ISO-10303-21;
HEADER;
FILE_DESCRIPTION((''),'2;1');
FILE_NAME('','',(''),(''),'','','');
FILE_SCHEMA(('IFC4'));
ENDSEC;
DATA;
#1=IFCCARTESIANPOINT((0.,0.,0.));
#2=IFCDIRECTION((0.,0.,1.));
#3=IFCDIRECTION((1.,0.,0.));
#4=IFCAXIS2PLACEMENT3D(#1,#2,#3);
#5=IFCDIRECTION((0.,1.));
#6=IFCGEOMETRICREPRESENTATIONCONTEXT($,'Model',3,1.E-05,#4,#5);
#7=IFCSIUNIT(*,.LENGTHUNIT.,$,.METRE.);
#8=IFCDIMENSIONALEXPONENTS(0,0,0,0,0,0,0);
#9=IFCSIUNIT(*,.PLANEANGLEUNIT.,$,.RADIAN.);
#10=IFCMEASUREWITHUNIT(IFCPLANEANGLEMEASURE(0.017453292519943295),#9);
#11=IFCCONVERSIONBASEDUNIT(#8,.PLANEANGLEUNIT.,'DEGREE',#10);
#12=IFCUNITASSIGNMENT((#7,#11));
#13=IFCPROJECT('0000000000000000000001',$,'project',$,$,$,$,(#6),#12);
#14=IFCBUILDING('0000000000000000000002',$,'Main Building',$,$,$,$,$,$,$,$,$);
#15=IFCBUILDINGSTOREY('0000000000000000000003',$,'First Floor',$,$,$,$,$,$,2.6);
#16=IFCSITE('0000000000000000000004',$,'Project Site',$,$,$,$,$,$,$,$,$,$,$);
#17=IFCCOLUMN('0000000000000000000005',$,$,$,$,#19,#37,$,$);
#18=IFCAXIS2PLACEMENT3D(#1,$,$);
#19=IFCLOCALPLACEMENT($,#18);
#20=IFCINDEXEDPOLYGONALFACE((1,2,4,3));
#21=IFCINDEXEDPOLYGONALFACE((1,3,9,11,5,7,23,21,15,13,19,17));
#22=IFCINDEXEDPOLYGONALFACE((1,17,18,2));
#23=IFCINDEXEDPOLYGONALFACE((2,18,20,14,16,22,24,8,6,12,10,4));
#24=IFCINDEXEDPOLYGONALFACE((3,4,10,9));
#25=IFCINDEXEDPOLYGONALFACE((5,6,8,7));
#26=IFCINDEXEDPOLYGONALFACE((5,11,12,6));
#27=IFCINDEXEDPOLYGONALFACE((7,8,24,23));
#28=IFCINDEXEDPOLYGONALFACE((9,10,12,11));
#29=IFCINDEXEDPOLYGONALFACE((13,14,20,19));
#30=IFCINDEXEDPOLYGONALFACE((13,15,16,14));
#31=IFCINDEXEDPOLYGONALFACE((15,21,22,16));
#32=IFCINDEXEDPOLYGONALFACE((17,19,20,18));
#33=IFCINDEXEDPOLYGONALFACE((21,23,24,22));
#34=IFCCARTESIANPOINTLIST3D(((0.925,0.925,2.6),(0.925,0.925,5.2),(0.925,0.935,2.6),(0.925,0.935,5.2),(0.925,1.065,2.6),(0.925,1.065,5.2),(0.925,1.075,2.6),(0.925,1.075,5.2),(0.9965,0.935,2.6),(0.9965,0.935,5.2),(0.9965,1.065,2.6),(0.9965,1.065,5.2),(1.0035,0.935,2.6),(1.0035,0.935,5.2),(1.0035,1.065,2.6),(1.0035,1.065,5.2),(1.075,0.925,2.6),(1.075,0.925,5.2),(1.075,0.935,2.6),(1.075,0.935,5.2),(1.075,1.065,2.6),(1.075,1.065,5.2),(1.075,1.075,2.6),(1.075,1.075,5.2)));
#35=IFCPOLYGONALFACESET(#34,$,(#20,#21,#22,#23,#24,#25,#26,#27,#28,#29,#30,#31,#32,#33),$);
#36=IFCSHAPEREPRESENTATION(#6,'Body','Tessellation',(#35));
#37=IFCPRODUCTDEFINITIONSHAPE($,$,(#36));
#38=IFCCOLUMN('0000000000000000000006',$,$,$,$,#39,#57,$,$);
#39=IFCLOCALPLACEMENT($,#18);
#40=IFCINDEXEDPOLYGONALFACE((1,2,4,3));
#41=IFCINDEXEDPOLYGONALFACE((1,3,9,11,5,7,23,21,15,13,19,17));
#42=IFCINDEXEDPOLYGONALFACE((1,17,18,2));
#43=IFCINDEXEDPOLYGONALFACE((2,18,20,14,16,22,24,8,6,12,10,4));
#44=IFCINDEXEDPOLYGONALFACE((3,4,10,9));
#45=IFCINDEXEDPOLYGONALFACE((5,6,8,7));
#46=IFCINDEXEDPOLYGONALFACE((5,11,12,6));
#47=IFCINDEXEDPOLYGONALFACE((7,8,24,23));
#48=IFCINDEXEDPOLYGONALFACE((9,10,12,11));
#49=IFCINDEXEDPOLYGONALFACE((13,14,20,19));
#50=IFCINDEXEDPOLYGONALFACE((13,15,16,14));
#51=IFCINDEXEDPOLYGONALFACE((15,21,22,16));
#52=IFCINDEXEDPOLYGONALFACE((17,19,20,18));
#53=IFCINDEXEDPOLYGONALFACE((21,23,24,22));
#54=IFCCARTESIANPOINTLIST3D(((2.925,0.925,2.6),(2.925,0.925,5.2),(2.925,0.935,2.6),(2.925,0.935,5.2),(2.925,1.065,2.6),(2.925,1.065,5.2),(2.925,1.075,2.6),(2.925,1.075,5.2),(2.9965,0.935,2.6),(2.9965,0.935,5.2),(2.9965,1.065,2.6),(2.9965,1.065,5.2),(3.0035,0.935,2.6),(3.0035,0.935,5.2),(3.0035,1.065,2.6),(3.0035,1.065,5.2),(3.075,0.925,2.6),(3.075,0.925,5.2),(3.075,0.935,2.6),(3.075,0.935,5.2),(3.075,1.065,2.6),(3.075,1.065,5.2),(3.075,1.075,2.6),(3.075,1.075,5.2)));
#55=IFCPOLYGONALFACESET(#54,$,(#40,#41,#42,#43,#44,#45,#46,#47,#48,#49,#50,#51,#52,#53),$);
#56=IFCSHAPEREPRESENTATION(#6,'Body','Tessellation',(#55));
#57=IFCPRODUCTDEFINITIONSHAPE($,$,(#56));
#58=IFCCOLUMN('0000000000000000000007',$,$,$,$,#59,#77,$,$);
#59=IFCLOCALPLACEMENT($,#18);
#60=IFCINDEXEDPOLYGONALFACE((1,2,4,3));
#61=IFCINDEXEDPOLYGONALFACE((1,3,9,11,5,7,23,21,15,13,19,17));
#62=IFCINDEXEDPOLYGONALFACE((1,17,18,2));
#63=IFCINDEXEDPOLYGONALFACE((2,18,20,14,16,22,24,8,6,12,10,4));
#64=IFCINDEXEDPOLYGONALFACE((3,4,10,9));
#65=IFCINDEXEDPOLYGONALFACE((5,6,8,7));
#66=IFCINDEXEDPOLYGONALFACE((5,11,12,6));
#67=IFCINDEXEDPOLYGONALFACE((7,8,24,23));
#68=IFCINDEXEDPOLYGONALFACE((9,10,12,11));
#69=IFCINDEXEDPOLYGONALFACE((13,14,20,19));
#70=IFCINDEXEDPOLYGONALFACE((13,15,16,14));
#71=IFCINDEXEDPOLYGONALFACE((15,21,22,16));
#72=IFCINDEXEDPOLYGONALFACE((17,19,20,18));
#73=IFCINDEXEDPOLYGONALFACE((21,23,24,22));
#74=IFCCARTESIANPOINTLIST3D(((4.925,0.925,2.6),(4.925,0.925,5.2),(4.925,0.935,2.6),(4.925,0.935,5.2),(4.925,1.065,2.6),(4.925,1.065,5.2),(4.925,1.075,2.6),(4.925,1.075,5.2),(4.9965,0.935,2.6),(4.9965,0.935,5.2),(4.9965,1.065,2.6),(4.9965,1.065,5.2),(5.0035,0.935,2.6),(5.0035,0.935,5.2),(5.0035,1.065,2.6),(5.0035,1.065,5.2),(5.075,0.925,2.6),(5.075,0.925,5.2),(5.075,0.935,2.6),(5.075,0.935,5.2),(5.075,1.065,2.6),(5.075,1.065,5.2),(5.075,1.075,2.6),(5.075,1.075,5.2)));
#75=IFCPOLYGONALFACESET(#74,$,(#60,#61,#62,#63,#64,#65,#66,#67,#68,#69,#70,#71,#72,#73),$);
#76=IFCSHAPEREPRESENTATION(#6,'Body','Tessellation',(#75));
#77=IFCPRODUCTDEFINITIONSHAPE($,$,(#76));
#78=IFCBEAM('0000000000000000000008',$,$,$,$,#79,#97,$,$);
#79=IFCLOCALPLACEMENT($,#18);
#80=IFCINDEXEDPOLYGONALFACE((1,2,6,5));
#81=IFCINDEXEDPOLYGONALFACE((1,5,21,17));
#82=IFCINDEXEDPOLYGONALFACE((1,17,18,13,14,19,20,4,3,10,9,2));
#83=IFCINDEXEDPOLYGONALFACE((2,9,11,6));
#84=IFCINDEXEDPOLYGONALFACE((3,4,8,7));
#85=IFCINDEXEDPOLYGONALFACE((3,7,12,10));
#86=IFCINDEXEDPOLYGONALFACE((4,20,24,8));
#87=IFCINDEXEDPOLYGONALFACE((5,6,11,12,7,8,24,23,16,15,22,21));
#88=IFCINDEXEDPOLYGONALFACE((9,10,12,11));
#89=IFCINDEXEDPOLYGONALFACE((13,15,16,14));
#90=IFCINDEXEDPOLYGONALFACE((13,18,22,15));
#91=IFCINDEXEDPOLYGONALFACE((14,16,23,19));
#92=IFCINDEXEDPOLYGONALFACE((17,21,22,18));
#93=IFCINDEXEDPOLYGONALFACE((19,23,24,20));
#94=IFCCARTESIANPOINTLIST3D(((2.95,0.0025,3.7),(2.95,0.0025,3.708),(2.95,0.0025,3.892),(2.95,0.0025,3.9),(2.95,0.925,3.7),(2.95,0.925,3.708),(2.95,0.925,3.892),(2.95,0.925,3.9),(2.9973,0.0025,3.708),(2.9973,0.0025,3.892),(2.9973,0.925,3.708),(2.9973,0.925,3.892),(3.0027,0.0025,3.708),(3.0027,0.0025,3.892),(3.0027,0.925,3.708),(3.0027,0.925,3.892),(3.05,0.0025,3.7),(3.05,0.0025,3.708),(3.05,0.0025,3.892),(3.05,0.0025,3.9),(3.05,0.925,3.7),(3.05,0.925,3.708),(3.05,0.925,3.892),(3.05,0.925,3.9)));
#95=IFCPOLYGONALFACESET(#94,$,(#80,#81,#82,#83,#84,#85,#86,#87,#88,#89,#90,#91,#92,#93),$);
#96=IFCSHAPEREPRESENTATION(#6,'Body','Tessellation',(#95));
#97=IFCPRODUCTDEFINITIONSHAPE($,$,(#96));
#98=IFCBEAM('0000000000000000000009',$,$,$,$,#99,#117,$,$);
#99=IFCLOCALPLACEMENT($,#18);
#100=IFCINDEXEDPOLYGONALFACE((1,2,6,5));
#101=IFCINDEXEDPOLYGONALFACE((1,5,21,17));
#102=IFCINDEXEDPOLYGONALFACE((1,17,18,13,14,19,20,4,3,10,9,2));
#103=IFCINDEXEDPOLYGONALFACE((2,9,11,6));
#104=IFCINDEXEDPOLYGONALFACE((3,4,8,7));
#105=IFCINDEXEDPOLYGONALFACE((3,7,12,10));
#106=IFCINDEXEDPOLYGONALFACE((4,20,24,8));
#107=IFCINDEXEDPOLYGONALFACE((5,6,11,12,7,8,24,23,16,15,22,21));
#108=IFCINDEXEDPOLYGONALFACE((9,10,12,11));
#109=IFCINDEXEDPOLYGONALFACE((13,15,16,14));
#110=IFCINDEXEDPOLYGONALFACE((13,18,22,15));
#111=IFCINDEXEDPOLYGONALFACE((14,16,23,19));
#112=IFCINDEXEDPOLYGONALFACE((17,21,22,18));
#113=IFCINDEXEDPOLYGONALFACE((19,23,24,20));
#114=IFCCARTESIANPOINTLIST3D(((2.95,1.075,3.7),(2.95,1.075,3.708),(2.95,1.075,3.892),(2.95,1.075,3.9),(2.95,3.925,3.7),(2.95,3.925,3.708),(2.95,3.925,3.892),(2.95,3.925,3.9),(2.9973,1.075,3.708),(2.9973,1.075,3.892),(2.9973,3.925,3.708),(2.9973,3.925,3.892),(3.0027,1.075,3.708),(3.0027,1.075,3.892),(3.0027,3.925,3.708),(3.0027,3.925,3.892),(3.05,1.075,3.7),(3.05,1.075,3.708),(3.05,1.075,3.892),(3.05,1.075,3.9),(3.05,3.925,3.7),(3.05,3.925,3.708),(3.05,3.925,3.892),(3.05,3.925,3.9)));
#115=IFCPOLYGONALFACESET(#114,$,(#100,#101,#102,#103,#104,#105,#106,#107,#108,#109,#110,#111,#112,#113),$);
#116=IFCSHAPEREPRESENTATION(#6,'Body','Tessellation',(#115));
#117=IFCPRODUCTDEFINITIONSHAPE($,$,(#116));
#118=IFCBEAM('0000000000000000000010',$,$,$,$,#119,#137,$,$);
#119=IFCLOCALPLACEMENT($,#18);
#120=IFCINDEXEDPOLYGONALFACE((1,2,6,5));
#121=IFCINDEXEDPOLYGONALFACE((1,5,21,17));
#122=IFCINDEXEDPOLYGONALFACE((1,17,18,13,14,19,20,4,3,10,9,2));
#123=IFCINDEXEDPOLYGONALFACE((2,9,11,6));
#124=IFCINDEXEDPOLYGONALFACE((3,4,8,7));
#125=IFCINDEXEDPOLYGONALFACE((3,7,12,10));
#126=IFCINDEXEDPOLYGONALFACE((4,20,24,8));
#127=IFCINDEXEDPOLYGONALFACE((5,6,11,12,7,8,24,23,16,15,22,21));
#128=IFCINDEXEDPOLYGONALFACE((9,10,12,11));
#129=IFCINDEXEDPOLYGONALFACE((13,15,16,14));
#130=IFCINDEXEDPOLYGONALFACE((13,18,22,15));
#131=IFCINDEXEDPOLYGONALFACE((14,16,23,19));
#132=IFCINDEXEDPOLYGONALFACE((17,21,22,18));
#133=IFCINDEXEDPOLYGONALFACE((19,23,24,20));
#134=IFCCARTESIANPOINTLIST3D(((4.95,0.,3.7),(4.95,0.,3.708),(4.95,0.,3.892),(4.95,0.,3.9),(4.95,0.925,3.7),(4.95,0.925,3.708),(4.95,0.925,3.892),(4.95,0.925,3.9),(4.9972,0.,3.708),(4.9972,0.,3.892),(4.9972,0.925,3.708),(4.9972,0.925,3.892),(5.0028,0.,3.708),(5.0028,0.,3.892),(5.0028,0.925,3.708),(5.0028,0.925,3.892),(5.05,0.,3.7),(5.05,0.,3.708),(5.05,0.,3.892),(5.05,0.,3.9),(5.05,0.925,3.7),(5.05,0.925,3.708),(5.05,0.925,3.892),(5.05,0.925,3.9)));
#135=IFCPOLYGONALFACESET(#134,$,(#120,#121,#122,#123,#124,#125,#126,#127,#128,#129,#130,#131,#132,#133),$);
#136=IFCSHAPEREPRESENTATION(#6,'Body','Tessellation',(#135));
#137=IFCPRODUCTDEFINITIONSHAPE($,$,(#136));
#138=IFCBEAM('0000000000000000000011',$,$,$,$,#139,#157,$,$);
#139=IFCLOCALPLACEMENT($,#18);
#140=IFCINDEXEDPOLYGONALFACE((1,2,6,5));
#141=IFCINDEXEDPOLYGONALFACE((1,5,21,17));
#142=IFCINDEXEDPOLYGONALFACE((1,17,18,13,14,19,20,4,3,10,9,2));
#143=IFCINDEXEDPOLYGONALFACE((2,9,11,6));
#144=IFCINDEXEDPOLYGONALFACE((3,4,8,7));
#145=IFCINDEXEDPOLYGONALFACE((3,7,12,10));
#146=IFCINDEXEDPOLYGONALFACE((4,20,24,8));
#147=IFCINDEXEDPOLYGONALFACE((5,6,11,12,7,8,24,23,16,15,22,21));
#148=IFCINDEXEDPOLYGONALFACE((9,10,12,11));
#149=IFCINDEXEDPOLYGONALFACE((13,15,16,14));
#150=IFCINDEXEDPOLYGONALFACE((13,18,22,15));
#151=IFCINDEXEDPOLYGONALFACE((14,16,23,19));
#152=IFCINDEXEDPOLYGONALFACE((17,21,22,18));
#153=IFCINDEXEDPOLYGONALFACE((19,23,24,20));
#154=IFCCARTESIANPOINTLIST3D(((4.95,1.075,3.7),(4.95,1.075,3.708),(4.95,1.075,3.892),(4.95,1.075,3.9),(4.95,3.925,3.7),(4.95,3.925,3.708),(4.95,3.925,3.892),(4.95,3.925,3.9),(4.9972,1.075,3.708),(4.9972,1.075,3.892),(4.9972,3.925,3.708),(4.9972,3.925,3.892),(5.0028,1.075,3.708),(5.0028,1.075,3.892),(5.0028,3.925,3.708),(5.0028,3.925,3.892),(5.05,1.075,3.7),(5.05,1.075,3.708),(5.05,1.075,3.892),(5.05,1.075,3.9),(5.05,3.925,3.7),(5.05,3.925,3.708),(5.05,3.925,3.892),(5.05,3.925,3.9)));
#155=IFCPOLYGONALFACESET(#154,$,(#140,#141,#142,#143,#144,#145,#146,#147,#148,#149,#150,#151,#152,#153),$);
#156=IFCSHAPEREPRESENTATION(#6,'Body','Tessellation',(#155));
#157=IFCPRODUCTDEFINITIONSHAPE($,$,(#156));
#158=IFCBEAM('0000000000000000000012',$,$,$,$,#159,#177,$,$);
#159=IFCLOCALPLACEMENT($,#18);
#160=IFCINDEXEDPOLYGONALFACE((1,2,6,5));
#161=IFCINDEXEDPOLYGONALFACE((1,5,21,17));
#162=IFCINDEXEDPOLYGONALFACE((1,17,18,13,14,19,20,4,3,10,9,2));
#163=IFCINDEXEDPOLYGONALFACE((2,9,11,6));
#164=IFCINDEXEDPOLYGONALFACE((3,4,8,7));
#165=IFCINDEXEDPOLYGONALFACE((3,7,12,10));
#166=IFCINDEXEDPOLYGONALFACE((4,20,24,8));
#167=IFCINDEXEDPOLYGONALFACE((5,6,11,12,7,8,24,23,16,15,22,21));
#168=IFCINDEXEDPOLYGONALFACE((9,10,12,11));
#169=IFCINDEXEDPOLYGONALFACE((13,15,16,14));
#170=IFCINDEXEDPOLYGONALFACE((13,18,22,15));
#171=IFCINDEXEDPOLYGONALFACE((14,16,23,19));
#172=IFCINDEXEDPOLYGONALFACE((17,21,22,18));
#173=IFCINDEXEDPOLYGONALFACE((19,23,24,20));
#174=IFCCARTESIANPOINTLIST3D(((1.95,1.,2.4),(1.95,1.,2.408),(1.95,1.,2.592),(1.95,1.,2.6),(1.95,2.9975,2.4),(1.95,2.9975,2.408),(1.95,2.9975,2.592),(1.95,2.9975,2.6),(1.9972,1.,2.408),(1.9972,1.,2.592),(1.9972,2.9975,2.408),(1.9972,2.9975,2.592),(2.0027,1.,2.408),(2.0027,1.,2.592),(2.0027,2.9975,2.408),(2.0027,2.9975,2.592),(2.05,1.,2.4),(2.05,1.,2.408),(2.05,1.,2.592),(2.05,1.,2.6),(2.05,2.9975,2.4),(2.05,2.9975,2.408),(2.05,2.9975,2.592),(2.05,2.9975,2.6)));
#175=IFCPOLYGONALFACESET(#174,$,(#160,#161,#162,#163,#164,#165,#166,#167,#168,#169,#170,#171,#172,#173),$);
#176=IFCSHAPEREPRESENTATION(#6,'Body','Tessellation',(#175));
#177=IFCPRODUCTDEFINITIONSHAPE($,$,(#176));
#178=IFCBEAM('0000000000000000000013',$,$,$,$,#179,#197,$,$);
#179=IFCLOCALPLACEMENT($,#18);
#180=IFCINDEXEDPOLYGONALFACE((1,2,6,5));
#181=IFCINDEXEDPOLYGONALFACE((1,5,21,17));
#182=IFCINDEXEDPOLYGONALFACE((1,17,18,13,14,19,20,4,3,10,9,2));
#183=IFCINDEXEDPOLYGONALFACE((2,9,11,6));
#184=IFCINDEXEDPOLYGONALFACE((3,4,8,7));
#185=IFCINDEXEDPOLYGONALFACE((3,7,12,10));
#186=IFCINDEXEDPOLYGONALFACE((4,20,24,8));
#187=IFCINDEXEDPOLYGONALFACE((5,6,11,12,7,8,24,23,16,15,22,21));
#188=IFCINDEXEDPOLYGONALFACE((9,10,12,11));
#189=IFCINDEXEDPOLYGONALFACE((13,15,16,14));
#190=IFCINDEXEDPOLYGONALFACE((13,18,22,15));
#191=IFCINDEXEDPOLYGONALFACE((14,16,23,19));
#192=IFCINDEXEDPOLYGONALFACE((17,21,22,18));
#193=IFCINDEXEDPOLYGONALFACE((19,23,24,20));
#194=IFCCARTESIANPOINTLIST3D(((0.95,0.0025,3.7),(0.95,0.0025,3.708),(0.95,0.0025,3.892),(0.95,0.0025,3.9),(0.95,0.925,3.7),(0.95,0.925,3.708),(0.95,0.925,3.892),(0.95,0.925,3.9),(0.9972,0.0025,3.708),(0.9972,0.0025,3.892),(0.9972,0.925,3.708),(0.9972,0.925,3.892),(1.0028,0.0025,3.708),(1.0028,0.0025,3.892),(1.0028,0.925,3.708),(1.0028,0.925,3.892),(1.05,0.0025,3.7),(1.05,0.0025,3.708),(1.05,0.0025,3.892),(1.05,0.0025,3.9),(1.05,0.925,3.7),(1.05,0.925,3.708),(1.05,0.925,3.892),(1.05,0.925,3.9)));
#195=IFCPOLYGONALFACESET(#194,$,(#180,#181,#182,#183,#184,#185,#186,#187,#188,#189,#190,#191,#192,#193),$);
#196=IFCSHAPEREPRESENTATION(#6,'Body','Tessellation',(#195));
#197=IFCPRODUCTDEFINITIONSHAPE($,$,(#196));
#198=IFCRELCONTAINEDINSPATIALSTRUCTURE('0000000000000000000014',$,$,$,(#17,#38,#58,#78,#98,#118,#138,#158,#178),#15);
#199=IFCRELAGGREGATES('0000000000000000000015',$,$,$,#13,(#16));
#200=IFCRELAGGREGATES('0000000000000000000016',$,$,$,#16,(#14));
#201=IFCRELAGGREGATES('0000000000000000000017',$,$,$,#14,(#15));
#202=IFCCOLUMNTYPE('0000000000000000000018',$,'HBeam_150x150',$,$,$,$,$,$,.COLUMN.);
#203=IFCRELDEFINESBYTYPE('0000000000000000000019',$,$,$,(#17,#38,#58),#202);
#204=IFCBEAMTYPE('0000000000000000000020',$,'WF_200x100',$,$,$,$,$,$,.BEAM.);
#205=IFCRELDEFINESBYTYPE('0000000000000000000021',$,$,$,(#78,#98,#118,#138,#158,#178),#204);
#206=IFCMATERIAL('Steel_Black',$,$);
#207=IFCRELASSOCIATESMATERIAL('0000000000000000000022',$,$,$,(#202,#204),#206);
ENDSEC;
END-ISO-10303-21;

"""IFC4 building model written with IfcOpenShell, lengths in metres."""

from ifc_helpers import new_model, entity, si_unit, converted_unit, direction, frame, frame_2d, origin, origin_with_axes, origin_2d, place, context, project, spatial, i_section, extrude, material, material_profile, profile_set, type_object, element, save


model = new_model("IFC4")

# Units and contexts
model_context = context("Model", 3, precision=1e-05, world=origin_with_axes(), true_north=direction((0.0, 1.0)))
ifc_project = project(units=[si_unit("LENGTHUNIT", "METRE"), converted_unit("PLANEANGLEUNIT", "DEGREE", entity("IfcPlaneAngleMeasure", 0.017453292519943295), si_unit("PLANEANGLEUNIT", "RADIAN"), dimensions=[0, 0, 0, 0, 0, 0, 0])], contexts=[model_context])

# Site, building, storey
site = spatial("IfcSite", under=ifc_project, Name="Project Site")
building = spatial("IfcBuilding", under=site, Name="Main Building")
storey = spatial("IfcBuildingStorey", under=building, Name="First Floor", Elevation=2.6)

# Columns
ifc_material_1 = material(Name="Steel_Black")
ifc_material_profile_1 = material_profile(ifc_material_1, i_section(OverallWidth=0.15, OverallDepth=0.15, WebThickness=0.007, FlangeThickness=0.01, at=origin_2d()), Name="HBeam_150x150")
ifc_profile_set_1 = profile_set([ifc_material_profile_1], Name="HBeam_150x150")
column_type = type_object("IfcColumnType", Name="HBeam_150x150", PredefinedType="COLUMN", material=ifc_profile_set_1)
for number, where, z_axis, x_axis in (
    (1, (1.0, 1.0, 2.6), (0.0, 0.0, 1.0), (1.0, 0.0, 0.0)),
    (2, (3.0, 1.0, 2.6), (0.0, 0.0, 1.0), (1.0, 0.0, 0.0)),
    (3, (5.0, 1.0, 2.6), (0.0, 0.0, 1.0), (1.0, 0.0, 0.0)),
):
    element("IfcColumn", number, at=place(None, frame(where, z_axis=z_axis, x_axis=x_axis)), inside=storey, type_object=column_type, context=model_context, shape_type="SweptSolid", body=[
        extrude(i_section(OverallWidth=0.15, OverallDepth=0.15, WebThickness=0.007, FlangeThickness=0.01, at=origin_2d()), origin(), (0.0, 0.0, 1.0), 2.6),
    ])

# Beams
ifc_material_profile_2 = material_profile(ifc_material_1, i_section(OverallWidth=0.1, OverallDepth=0.2, WebThickness=0.0055, FlangeThickness=0.008, at=origin_2d()), Name="WF_200x100")
ifc_profile_set_2 = profile_set([ifc_material_profile_2], Name="WF_200x100")
beam_type_1 = type_object("IfcBeamType", Name="WF_200x100", PredefinedType="BEAM", material=ifc_profile_set_2)
beam_1_placement = place(None, frame((3.0, 0.0025, 3.7), z_axis=(0.0, 0.0, 1.0), x_axis=(0.0, 1.0, 0.0)))
element("IfcBeam", 4, at=beam_1_placement, inside=storey, type_object=beam_type_1, context=model_context, shape_type="SweptSolid", body=[
    extrude(i_section(OverallWidth=0.1, OverallDepth=0.2, WebThickness=0.0055, FlangeThickness=0.008, at=frame_2d((0.0, 0.1))), frame((0.0, 0.0, 0.0), z_axis=(1.0, 0.0, 0.0), x_axis=(0.0, 1.0, 0.0)), (0.0, 0.0, 1.0), 0.9225),
])
beam_2_placement = place(None, frame((3.0, 1.075, 3.7), z_axis=(0.0, 0.0, 1.0), x_axis=(0.0, 1.0, 0.0)))
element("IfcBeam", 5, at=beam_2_placement, inside=storey, type_object=beam_type_1, context=model_context, shape_type="SweptSolid", body=[
    extrude(i_section(OverallWidth=0.1, OverallDepth=0.2, WebThickness=0.0055, FlangeThickness=0.008, at=frame_2d((0.0, 0.1))), frame((0.0, 0.0, 0.0), z_axis=(1.0, 0.0, 0.0), x_axis=(0.0, 1.0, 0.0)), (0.0, 0.0, 1.0), 2.85),
])
beam_3_placement = place(None, frame((5.0, 0.0, 3.7), z_axis=(0.0, 0.0, 1.0), x_axis=(0.0, 1.0, 0.0)))
element("IfcBeam", 6, at=beam_3_placement, inside=storey, type_object=beam_type_1, context=model_context, shape_type="SweptSolid", body=[
    extrude(i_section(OverallWidth=0.1, OverallDepth=0.2, WebThickness=0.0055, FlangeThickness=0.008, at=frame_2d((0.0, 0.1))), frame((0.0, 0.0, 0.0), z_axis=(1.0, 0.0, 0.0), x_axis=(0.0, 1.0, 0.0)), (0.0, 0.0, 1.0), 0.925),
])
beam_4_placement = place(None, frame((5.0, 1.075, 3.7), z_axis=(0.0, 0.0, 1.0), x_axis=(0.0, 1.0, 0.0)))
element("IfcBeam", 7, at=beam_4_placement, inside=storey, type_object=beam_type_1, context=model_context, shape_type="SweptSolid", body=[
    extrude(i_section(OverallWidth=0.1, OverallDepth=0.2, WebThickness=0.0055, FlangeThickness=0.008, at=frame_2d((0.0, 0.1))), frame((0.0, 0.0, 0.0), z_axis=(1.0, 0.0, 0.0), x_axis=(0.0, 1.0, 0.0)), (0.0, 0.0, 1.0), 2.85),
])
beam_5_placement = place(None, frame((2.0, 1.0, 2.4), z_axis=(0.0, 0.0, 1.0), x_axis=(0.0, 1.0, 0.0)))
element("IfcBeam", 8, at=beam_5_placement, inside=storey, type_object=beam_type_1, context=model_context, shape_type="SweptSolid", body=[
    extrude(i_section(OverallWidth=0.1, OverallDepth=0.2, WebThickness=0.0055, FlangeThickness=0.008, at=frame_2d((0.0, 0.1))), frame((0.0, 0.0, 0.0), z_axis=(1.0, 0.0, 0.0), x_axis=(0.0, 1.0, 0.0)), (0.0, 0.0, 1.0), 1.9975),
])
beam_6_placement = place(None, frame((1.0, 0.0025, 3.7), z_axis=(0.0, 0.0, 1.0), x_axis=(0.0, 1.0, 0.0)))
element("IfcBeam", 9, at=beam_6_placement, inside=storey, type_object=beam_type_1, context=model_context, shape_type="SweptSolid", body=[
    extrude(i_section(OverallWidth=0.1, OverallDepth=0.2, WebThickness=0.0055, FlangeThickness=0.008, at=frame_2d((0.0, 0.1))), frame((0.0, 0.0, 0.0), z_axis=(1.0, 0.0, 0.0), x_axis=(0.0, 1.0, 0.0)), (0.0, 0.0, 1.0), 0.9225),
])

save(model, "model.ifc")
